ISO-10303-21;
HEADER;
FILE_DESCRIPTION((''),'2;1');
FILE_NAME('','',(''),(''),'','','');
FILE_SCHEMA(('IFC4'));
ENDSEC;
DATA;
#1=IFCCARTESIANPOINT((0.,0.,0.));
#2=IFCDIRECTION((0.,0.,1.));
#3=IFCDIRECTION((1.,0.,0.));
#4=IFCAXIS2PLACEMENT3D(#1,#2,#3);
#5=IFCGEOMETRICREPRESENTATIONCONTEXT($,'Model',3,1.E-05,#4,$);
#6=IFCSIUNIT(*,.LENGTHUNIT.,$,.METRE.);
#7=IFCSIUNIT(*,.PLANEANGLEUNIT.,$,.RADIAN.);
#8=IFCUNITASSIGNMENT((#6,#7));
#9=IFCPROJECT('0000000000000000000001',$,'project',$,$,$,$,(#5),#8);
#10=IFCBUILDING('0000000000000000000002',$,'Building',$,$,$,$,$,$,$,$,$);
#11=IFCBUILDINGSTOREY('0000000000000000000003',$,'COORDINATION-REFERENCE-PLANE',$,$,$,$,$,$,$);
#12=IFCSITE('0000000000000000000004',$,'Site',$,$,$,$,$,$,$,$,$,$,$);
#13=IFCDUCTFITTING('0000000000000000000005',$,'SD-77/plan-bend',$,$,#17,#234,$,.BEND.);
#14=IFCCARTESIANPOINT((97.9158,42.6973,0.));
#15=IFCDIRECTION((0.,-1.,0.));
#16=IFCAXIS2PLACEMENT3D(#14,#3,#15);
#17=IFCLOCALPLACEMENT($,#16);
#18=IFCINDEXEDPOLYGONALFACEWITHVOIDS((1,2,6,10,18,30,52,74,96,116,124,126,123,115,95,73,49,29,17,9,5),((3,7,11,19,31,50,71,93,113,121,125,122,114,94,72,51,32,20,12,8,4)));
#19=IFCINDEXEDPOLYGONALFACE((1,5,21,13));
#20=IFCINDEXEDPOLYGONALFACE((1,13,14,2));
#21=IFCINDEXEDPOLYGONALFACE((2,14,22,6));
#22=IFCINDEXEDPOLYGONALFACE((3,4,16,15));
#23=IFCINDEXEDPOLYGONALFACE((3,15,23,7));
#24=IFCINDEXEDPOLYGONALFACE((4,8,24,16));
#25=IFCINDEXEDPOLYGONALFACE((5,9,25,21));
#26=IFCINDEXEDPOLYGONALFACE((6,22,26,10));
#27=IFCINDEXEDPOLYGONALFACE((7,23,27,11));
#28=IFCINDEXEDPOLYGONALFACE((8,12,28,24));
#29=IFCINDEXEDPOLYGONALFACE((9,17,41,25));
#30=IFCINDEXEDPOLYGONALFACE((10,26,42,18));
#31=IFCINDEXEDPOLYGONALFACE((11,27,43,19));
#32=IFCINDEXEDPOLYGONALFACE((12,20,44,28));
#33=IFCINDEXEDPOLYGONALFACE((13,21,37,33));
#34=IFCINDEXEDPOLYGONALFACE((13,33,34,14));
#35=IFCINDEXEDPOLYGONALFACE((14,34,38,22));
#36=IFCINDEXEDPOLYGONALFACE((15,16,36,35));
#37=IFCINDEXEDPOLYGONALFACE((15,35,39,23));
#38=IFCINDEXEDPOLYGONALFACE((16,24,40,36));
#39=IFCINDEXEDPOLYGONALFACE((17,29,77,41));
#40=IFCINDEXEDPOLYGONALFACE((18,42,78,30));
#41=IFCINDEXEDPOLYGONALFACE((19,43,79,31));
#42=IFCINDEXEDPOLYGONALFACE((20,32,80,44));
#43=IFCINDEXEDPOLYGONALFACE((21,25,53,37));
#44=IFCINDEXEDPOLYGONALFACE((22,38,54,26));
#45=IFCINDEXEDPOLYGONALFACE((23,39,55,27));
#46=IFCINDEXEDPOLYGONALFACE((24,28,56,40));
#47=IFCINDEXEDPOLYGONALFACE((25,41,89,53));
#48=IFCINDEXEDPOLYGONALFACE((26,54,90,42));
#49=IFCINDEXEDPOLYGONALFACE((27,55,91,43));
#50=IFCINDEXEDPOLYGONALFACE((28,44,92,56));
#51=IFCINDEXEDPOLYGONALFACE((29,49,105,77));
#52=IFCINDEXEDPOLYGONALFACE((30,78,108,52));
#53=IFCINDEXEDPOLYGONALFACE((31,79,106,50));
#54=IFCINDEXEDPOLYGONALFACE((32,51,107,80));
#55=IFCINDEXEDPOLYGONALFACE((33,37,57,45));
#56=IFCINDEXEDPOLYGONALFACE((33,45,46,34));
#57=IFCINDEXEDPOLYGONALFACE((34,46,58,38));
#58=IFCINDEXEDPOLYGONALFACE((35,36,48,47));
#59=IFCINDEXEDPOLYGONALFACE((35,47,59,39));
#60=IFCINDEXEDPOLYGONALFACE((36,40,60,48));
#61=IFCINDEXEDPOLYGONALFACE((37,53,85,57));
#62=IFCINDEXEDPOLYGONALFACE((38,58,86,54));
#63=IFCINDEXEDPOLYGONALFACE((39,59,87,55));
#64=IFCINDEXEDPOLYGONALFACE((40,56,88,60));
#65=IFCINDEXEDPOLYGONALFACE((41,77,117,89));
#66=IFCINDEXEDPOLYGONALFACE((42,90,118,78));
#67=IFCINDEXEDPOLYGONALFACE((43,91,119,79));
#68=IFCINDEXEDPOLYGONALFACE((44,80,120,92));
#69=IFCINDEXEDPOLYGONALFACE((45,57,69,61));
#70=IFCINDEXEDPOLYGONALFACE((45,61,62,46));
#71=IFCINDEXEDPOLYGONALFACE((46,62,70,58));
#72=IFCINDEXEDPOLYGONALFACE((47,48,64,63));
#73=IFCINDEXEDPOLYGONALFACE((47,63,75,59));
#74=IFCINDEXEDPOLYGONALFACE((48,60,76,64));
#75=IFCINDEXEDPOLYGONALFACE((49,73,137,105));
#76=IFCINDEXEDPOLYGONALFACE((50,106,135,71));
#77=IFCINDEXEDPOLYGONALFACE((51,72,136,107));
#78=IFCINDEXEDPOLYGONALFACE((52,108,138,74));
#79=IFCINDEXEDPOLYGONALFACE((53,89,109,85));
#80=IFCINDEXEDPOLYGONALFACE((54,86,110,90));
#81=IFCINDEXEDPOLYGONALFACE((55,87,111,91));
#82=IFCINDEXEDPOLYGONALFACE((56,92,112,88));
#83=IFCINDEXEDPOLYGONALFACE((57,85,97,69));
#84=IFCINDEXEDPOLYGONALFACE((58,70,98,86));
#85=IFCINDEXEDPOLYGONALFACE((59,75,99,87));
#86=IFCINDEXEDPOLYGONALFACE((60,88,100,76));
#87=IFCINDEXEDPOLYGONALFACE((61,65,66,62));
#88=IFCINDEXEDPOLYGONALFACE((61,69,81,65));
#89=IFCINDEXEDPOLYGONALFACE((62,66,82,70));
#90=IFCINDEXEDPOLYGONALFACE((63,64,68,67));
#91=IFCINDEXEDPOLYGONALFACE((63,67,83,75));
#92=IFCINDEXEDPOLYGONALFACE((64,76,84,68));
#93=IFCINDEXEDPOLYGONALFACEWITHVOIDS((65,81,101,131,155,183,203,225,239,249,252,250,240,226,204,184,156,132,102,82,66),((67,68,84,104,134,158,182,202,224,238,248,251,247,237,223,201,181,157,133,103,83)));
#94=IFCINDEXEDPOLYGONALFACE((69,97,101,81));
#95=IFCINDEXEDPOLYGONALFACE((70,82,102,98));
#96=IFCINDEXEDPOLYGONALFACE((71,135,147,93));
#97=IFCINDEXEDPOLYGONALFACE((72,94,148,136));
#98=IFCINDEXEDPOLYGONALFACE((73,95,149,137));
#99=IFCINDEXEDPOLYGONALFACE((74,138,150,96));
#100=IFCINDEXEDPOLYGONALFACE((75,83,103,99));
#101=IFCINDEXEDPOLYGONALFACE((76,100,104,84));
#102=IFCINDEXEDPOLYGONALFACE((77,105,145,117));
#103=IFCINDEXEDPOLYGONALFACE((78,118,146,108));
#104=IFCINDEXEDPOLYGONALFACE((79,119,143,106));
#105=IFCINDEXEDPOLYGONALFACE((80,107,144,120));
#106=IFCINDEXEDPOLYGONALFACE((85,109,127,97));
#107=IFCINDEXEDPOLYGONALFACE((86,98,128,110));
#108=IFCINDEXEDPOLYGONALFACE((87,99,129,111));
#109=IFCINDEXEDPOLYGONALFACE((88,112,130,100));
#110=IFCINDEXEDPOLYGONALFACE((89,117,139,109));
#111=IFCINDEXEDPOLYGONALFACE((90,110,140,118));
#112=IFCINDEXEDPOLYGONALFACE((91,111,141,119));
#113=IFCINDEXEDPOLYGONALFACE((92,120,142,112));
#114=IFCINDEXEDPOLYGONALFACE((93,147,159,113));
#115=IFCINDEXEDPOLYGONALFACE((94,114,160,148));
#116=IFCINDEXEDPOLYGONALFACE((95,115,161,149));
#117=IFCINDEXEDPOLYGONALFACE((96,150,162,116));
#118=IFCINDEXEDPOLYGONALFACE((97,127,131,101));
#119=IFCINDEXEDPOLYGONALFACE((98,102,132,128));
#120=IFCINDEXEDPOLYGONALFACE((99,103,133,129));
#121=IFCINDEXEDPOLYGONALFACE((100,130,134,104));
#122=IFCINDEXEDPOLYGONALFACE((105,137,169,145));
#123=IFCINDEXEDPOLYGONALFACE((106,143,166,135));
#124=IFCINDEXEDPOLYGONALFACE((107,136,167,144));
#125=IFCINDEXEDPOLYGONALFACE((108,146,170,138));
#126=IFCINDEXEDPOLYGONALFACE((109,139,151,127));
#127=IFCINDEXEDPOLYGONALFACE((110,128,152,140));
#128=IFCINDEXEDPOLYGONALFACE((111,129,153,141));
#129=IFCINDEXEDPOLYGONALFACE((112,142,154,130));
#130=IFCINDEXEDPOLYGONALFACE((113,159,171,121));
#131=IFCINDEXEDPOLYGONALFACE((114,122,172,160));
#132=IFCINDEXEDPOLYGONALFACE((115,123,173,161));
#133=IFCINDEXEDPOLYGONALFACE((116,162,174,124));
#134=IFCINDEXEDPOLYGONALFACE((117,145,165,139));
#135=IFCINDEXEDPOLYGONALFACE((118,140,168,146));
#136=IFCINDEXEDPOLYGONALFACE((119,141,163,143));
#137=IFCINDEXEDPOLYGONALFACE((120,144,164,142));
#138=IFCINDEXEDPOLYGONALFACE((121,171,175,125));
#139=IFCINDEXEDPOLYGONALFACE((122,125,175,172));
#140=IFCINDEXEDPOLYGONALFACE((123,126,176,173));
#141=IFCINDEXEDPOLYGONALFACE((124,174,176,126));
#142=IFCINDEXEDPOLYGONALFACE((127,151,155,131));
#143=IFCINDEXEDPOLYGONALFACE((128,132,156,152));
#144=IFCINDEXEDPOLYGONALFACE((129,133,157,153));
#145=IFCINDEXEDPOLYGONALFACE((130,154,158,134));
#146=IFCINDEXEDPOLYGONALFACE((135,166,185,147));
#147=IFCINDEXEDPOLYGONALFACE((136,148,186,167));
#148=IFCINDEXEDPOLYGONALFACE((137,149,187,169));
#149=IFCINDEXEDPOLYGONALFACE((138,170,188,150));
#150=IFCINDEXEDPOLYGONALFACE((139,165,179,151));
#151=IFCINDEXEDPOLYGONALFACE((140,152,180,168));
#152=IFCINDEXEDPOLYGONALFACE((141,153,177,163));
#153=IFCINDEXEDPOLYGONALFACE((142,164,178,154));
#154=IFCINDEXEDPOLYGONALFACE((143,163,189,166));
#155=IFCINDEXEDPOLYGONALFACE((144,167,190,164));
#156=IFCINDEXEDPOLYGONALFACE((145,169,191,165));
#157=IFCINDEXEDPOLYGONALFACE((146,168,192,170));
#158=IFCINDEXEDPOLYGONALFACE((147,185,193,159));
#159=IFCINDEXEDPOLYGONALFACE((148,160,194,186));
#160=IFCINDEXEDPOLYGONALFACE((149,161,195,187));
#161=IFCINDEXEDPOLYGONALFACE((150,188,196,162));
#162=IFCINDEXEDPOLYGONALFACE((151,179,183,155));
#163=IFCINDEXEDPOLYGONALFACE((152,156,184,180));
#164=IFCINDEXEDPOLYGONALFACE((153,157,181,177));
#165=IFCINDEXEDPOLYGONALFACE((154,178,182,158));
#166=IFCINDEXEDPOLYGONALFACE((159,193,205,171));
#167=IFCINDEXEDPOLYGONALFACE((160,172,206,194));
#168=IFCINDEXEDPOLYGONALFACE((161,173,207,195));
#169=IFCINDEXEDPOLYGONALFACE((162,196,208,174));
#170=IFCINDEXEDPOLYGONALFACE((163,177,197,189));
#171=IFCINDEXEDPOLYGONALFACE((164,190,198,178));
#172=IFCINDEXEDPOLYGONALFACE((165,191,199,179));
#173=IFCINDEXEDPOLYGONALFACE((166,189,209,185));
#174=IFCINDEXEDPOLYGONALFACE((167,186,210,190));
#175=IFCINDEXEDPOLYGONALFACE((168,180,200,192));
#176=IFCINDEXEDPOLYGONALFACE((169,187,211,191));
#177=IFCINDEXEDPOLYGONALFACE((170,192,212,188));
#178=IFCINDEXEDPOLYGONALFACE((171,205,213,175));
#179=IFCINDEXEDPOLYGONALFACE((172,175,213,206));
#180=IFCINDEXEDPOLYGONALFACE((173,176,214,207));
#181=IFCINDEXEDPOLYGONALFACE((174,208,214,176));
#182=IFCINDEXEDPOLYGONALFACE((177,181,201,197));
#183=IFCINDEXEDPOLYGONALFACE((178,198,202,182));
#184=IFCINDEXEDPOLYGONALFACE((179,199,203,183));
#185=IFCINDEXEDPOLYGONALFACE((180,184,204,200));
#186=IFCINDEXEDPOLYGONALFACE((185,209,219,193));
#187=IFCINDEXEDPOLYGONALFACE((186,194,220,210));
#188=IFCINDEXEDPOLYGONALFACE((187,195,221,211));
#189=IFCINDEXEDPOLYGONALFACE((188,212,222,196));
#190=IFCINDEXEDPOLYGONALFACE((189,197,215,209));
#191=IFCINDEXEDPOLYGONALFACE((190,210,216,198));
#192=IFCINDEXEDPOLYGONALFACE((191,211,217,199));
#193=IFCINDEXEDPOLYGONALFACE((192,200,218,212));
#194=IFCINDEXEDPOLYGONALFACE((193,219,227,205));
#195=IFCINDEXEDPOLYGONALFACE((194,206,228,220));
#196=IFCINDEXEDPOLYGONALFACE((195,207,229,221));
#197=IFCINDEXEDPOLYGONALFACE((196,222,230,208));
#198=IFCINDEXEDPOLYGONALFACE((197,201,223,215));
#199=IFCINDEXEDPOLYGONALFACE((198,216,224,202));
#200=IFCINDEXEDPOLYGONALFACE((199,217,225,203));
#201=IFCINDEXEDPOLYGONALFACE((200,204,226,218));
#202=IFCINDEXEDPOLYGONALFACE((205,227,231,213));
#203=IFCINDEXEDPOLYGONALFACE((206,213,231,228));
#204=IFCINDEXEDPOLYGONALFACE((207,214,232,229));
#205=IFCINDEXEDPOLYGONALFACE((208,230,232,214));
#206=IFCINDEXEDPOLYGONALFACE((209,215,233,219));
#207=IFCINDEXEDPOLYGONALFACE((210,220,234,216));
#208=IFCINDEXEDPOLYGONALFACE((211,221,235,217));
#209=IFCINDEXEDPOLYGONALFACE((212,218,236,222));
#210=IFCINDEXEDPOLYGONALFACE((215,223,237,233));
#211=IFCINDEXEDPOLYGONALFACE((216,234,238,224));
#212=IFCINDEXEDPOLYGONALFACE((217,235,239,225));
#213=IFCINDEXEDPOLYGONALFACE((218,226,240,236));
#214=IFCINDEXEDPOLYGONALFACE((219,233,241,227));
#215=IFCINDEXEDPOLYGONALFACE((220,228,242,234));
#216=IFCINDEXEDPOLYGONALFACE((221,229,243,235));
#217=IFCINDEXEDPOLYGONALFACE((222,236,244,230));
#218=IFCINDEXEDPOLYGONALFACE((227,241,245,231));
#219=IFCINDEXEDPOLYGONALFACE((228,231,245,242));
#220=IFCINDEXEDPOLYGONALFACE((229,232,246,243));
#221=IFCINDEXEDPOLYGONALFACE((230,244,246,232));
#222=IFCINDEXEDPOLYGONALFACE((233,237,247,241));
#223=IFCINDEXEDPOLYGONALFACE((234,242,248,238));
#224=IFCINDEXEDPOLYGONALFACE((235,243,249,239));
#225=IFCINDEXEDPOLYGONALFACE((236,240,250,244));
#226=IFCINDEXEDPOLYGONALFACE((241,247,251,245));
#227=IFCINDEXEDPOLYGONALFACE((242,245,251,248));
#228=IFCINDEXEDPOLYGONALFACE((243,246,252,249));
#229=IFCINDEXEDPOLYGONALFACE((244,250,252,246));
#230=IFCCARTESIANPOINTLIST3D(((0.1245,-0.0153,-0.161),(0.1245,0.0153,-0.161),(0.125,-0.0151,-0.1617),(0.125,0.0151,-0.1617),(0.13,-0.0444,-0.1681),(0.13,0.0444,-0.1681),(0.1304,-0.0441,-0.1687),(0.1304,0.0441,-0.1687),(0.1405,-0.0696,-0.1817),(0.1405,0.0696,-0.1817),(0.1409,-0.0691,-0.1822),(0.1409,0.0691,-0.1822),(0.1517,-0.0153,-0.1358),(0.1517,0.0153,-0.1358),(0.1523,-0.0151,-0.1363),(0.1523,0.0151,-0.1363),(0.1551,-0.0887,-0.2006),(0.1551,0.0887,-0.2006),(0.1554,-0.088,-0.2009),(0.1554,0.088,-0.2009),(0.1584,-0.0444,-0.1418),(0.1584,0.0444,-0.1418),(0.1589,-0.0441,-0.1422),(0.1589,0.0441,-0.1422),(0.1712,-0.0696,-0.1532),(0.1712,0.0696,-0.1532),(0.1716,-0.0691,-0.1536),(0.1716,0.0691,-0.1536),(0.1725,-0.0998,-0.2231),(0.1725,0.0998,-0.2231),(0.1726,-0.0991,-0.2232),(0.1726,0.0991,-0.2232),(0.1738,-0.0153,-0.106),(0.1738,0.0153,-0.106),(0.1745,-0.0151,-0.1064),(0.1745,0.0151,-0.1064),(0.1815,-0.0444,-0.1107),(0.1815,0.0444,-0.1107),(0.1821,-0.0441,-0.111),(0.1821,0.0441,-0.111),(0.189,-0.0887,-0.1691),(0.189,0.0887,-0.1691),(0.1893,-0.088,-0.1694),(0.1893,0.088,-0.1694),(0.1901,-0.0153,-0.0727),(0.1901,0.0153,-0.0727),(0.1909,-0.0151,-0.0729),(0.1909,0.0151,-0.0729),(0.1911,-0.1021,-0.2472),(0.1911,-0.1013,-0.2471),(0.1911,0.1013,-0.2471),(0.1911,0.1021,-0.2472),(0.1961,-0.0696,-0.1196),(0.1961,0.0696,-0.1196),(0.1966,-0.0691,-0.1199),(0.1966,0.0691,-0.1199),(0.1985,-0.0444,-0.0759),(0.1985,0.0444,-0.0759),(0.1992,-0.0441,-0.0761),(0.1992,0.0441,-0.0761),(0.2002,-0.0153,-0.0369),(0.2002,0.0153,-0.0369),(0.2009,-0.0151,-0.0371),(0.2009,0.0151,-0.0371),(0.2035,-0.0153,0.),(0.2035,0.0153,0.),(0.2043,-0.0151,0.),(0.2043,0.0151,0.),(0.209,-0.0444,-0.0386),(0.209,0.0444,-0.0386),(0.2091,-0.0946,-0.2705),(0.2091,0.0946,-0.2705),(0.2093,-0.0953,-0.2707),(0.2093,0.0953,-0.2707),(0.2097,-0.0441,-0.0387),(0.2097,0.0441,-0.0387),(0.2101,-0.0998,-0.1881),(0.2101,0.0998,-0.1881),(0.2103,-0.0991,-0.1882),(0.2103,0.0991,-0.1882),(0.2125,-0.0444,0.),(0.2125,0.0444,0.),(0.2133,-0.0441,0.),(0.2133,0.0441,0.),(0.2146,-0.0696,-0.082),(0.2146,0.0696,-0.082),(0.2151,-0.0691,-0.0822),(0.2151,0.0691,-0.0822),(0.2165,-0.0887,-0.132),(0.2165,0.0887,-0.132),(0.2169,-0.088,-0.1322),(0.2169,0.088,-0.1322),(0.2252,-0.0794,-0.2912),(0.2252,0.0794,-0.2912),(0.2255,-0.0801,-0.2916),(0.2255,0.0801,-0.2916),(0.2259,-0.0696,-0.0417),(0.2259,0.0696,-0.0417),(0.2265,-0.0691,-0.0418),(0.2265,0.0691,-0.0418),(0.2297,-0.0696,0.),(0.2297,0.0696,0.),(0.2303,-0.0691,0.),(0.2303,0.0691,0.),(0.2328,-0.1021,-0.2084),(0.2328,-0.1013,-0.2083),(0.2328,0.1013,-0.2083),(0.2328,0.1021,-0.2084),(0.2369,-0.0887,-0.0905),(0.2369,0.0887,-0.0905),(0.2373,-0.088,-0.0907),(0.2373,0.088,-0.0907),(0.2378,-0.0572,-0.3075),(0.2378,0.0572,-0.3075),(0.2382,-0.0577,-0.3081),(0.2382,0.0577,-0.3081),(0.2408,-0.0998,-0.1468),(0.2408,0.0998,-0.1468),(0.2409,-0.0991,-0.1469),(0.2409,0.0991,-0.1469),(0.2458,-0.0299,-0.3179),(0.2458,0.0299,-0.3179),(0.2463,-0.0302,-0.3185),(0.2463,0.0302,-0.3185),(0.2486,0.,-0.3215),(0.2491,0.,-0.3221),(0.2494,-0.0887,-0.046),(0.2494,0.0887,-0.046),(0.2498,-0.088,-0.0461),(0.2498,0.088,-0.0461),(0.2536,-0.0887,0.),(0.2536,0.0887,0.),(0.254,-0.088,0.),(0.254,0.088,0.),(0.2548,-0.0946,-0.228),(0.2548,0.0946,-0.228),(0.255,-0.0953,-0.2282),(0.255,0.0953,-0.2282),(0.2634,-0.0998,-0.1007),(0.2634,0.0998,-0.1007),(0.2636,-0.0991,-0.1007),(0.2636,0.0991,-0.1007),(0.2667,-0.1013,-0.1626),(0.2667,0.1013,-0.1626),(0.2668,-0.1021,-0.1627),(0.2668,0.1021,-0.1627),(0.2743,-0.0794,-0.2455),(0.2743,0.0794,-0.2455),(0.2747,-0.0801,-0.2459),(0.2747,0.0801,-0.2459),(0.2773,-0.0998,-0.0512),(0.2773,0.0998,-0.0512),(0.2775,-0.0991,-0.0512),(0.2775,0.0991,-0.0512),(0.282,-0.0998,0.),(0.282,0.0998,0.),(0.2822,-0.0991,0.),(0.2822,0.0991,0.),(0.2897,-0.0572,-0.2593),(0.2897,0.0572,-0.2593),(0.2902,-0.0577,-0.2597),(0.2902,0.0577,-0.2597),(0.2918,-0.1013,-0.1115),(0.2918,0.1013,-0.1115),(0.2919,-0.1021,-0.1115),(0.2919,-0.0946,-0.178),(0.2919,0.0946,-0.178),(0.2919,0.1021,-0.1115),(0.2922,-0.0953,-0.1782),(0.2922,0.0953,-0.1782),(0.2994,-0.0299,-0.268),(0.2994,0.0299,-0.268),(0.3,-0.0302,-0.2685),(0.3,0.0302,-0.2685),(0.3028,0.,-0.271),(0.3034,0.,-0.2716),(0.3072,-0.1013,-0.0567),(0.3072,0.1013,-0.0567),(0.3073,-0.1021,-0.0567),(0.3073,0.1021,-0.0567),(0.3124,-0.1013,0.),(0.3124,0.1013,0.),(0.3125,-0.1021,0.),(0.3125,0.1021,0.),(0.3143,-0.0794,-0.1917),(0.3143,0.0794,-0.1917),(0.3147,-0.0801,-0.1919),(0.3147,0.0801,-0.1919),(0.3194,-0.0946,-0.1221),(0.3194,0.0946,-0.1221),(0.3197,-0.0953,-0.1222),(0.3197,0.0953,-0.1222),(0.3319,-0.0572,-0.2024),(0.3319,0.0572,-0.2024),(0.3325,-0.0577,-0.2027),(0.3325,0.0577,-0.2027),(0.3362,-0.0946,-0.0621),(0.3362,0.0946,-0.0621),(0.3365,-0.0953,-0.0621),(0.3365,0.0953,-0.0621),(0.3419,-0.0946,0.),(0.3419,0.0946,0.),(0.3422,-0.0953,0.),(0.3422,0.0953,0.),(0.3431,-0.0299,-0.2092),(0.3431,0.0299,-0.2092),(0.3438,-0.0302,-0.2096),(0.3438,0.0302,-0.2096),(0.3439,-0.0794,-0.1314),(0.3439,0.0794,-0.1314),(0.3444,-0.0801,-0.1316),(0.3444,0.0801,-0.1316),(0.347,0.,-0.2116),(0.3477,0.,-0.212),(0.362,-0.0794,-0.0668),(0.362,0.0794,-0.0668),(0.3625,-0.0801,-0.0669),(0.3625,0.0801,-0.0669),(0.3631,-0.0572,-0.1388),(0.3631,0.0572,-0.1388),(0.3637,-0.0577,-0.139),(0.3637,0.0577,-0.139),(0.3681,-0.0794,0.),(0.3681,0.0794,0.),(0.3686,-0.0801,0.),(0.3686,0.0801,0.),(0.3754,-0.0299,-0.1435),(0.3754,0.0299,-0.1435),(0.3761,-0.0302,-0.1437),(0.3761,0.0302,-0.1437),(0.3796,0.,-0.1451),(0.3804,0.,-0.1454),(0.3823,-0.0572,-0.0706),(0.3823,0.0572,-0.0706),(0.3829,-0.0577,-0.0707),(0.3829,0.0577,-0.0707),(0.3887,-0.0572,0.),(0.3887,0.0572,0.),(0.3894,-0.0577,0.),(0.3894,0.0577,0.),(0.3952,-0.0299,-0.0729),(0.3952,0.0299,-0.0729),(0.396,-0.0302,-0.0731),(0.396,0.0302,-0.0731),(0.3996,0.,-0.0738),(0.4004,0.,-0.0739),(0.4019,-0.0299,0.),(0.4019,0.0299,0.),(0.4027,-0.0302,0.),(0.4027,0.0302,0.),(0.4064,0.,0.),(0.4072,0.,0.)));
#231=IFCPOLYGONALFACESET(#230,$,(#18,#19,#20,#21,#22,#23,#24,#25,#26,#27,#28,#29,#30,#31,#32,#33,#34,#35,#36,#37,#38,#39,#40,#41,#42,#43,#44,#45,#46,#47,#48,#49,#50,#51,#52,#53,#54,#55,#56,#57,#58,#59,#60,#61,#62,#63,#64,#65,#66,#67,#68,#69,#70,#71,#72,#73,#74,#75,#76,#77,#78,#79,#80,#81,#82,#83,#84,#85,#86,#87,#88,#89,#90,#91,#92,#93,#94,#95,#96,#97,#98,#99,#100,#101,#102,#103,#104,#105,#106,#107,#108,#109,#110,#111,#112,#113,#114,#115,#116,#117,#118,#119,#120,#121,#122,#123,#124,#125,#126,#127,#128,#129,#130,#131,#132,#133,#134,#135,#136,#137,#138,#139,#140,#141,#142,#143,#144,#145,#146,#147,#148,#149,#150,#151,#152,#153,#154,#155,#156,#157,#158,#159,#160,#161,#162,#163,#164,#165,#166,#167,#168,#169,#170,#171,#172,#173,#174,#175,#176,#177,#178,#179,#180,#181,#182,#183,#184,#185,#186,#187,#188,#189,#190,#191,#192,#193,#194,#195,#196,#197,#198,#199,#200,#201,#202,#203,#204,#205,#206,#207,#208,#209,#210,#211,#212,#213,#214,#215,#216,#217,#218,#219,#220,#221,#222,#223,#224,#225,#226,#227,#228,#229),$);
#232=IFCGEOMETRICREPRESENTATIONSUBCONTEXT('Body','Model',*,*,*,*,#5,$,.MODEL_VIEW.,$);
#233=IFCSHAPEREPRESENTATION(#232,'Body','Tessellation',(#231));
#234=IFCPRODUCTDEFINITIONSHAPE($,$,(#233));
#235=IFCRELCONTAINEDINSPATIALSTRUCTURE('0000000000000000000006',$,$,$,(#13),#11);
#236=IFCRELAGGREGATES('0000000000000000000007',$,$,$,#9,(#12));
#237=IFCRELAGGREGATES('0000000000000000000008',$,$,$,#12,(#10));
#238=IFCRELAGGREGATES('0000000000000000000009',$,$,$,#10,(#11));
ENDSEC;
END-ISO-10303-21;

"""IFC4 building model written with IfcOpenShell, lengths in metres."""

from ifc_helpers import new_model, entity, si_unit, frame, origin_with_axes, place, context, subcontext, project, spatial, element, save


model = new_model("IFC4")

# Units and contexts
model_context_1 = context("Model", 3, precision=1e-05, world=origin_with_axes())
body_context_1 = subcontext(model_context_1, "Body", "Model", "MODEL_VIEW")
ifc_project = project(units=[si_unit("LENGTHUNIT", "METRE"), si_unit("PLANEANGLEUNIT", "RADIAN")], contexts=[model_context_1])

# Site, building, storey
site = spatial("IfcSite", under=ifc_project, Name="Site")
building = spatial("IfcBuilding", under=site, Name="Building")
storey = spatial("IfcBuildingStorey", under=building, Name="COORDINATION-REFERENCE-PLANE")

# Duct fitting
duct_fitting_1_placement = place(None, frame((97.9158, 42.6973, 0.0), z_axis=(1.0, 0.0, 0.0), x_axis=(0.0, -1.0, 0.0)))
element("IfcDuctFitting", 1, at=duct_fitting_1_placement, inside=storey, Name="SD-77/plan-bend", PredefinedType="BEND", context=body_context_1, shape_type="SweptSolid", body=[
    entity("IfcRevolvedAreaSolid", entity("IfcCircleHollowProfileDef", "AREA", None, entity("IfcAxis2Placement2D", entity("IfcCartesianPoint", [0.3048, 0.0])), 0.1024, 0.0008), entity("IfcAxis2Placement3D", entity("IfcCartesianPoint", [0.0, 0.0, 0.0]), entity("IfcDirection", [0.0, 0.0, 1.0]), entity("IfcDirection", [1.0, 0.0, 0.0])), entity("IfcAxis1Placement", entity("IfcCartesianPoint", [0.0, 0.0, 0.0]), entity("IfcDirection", [0.0, 1.0, 0.0])), 0.912619),
])

save(model, "model.ifc")
